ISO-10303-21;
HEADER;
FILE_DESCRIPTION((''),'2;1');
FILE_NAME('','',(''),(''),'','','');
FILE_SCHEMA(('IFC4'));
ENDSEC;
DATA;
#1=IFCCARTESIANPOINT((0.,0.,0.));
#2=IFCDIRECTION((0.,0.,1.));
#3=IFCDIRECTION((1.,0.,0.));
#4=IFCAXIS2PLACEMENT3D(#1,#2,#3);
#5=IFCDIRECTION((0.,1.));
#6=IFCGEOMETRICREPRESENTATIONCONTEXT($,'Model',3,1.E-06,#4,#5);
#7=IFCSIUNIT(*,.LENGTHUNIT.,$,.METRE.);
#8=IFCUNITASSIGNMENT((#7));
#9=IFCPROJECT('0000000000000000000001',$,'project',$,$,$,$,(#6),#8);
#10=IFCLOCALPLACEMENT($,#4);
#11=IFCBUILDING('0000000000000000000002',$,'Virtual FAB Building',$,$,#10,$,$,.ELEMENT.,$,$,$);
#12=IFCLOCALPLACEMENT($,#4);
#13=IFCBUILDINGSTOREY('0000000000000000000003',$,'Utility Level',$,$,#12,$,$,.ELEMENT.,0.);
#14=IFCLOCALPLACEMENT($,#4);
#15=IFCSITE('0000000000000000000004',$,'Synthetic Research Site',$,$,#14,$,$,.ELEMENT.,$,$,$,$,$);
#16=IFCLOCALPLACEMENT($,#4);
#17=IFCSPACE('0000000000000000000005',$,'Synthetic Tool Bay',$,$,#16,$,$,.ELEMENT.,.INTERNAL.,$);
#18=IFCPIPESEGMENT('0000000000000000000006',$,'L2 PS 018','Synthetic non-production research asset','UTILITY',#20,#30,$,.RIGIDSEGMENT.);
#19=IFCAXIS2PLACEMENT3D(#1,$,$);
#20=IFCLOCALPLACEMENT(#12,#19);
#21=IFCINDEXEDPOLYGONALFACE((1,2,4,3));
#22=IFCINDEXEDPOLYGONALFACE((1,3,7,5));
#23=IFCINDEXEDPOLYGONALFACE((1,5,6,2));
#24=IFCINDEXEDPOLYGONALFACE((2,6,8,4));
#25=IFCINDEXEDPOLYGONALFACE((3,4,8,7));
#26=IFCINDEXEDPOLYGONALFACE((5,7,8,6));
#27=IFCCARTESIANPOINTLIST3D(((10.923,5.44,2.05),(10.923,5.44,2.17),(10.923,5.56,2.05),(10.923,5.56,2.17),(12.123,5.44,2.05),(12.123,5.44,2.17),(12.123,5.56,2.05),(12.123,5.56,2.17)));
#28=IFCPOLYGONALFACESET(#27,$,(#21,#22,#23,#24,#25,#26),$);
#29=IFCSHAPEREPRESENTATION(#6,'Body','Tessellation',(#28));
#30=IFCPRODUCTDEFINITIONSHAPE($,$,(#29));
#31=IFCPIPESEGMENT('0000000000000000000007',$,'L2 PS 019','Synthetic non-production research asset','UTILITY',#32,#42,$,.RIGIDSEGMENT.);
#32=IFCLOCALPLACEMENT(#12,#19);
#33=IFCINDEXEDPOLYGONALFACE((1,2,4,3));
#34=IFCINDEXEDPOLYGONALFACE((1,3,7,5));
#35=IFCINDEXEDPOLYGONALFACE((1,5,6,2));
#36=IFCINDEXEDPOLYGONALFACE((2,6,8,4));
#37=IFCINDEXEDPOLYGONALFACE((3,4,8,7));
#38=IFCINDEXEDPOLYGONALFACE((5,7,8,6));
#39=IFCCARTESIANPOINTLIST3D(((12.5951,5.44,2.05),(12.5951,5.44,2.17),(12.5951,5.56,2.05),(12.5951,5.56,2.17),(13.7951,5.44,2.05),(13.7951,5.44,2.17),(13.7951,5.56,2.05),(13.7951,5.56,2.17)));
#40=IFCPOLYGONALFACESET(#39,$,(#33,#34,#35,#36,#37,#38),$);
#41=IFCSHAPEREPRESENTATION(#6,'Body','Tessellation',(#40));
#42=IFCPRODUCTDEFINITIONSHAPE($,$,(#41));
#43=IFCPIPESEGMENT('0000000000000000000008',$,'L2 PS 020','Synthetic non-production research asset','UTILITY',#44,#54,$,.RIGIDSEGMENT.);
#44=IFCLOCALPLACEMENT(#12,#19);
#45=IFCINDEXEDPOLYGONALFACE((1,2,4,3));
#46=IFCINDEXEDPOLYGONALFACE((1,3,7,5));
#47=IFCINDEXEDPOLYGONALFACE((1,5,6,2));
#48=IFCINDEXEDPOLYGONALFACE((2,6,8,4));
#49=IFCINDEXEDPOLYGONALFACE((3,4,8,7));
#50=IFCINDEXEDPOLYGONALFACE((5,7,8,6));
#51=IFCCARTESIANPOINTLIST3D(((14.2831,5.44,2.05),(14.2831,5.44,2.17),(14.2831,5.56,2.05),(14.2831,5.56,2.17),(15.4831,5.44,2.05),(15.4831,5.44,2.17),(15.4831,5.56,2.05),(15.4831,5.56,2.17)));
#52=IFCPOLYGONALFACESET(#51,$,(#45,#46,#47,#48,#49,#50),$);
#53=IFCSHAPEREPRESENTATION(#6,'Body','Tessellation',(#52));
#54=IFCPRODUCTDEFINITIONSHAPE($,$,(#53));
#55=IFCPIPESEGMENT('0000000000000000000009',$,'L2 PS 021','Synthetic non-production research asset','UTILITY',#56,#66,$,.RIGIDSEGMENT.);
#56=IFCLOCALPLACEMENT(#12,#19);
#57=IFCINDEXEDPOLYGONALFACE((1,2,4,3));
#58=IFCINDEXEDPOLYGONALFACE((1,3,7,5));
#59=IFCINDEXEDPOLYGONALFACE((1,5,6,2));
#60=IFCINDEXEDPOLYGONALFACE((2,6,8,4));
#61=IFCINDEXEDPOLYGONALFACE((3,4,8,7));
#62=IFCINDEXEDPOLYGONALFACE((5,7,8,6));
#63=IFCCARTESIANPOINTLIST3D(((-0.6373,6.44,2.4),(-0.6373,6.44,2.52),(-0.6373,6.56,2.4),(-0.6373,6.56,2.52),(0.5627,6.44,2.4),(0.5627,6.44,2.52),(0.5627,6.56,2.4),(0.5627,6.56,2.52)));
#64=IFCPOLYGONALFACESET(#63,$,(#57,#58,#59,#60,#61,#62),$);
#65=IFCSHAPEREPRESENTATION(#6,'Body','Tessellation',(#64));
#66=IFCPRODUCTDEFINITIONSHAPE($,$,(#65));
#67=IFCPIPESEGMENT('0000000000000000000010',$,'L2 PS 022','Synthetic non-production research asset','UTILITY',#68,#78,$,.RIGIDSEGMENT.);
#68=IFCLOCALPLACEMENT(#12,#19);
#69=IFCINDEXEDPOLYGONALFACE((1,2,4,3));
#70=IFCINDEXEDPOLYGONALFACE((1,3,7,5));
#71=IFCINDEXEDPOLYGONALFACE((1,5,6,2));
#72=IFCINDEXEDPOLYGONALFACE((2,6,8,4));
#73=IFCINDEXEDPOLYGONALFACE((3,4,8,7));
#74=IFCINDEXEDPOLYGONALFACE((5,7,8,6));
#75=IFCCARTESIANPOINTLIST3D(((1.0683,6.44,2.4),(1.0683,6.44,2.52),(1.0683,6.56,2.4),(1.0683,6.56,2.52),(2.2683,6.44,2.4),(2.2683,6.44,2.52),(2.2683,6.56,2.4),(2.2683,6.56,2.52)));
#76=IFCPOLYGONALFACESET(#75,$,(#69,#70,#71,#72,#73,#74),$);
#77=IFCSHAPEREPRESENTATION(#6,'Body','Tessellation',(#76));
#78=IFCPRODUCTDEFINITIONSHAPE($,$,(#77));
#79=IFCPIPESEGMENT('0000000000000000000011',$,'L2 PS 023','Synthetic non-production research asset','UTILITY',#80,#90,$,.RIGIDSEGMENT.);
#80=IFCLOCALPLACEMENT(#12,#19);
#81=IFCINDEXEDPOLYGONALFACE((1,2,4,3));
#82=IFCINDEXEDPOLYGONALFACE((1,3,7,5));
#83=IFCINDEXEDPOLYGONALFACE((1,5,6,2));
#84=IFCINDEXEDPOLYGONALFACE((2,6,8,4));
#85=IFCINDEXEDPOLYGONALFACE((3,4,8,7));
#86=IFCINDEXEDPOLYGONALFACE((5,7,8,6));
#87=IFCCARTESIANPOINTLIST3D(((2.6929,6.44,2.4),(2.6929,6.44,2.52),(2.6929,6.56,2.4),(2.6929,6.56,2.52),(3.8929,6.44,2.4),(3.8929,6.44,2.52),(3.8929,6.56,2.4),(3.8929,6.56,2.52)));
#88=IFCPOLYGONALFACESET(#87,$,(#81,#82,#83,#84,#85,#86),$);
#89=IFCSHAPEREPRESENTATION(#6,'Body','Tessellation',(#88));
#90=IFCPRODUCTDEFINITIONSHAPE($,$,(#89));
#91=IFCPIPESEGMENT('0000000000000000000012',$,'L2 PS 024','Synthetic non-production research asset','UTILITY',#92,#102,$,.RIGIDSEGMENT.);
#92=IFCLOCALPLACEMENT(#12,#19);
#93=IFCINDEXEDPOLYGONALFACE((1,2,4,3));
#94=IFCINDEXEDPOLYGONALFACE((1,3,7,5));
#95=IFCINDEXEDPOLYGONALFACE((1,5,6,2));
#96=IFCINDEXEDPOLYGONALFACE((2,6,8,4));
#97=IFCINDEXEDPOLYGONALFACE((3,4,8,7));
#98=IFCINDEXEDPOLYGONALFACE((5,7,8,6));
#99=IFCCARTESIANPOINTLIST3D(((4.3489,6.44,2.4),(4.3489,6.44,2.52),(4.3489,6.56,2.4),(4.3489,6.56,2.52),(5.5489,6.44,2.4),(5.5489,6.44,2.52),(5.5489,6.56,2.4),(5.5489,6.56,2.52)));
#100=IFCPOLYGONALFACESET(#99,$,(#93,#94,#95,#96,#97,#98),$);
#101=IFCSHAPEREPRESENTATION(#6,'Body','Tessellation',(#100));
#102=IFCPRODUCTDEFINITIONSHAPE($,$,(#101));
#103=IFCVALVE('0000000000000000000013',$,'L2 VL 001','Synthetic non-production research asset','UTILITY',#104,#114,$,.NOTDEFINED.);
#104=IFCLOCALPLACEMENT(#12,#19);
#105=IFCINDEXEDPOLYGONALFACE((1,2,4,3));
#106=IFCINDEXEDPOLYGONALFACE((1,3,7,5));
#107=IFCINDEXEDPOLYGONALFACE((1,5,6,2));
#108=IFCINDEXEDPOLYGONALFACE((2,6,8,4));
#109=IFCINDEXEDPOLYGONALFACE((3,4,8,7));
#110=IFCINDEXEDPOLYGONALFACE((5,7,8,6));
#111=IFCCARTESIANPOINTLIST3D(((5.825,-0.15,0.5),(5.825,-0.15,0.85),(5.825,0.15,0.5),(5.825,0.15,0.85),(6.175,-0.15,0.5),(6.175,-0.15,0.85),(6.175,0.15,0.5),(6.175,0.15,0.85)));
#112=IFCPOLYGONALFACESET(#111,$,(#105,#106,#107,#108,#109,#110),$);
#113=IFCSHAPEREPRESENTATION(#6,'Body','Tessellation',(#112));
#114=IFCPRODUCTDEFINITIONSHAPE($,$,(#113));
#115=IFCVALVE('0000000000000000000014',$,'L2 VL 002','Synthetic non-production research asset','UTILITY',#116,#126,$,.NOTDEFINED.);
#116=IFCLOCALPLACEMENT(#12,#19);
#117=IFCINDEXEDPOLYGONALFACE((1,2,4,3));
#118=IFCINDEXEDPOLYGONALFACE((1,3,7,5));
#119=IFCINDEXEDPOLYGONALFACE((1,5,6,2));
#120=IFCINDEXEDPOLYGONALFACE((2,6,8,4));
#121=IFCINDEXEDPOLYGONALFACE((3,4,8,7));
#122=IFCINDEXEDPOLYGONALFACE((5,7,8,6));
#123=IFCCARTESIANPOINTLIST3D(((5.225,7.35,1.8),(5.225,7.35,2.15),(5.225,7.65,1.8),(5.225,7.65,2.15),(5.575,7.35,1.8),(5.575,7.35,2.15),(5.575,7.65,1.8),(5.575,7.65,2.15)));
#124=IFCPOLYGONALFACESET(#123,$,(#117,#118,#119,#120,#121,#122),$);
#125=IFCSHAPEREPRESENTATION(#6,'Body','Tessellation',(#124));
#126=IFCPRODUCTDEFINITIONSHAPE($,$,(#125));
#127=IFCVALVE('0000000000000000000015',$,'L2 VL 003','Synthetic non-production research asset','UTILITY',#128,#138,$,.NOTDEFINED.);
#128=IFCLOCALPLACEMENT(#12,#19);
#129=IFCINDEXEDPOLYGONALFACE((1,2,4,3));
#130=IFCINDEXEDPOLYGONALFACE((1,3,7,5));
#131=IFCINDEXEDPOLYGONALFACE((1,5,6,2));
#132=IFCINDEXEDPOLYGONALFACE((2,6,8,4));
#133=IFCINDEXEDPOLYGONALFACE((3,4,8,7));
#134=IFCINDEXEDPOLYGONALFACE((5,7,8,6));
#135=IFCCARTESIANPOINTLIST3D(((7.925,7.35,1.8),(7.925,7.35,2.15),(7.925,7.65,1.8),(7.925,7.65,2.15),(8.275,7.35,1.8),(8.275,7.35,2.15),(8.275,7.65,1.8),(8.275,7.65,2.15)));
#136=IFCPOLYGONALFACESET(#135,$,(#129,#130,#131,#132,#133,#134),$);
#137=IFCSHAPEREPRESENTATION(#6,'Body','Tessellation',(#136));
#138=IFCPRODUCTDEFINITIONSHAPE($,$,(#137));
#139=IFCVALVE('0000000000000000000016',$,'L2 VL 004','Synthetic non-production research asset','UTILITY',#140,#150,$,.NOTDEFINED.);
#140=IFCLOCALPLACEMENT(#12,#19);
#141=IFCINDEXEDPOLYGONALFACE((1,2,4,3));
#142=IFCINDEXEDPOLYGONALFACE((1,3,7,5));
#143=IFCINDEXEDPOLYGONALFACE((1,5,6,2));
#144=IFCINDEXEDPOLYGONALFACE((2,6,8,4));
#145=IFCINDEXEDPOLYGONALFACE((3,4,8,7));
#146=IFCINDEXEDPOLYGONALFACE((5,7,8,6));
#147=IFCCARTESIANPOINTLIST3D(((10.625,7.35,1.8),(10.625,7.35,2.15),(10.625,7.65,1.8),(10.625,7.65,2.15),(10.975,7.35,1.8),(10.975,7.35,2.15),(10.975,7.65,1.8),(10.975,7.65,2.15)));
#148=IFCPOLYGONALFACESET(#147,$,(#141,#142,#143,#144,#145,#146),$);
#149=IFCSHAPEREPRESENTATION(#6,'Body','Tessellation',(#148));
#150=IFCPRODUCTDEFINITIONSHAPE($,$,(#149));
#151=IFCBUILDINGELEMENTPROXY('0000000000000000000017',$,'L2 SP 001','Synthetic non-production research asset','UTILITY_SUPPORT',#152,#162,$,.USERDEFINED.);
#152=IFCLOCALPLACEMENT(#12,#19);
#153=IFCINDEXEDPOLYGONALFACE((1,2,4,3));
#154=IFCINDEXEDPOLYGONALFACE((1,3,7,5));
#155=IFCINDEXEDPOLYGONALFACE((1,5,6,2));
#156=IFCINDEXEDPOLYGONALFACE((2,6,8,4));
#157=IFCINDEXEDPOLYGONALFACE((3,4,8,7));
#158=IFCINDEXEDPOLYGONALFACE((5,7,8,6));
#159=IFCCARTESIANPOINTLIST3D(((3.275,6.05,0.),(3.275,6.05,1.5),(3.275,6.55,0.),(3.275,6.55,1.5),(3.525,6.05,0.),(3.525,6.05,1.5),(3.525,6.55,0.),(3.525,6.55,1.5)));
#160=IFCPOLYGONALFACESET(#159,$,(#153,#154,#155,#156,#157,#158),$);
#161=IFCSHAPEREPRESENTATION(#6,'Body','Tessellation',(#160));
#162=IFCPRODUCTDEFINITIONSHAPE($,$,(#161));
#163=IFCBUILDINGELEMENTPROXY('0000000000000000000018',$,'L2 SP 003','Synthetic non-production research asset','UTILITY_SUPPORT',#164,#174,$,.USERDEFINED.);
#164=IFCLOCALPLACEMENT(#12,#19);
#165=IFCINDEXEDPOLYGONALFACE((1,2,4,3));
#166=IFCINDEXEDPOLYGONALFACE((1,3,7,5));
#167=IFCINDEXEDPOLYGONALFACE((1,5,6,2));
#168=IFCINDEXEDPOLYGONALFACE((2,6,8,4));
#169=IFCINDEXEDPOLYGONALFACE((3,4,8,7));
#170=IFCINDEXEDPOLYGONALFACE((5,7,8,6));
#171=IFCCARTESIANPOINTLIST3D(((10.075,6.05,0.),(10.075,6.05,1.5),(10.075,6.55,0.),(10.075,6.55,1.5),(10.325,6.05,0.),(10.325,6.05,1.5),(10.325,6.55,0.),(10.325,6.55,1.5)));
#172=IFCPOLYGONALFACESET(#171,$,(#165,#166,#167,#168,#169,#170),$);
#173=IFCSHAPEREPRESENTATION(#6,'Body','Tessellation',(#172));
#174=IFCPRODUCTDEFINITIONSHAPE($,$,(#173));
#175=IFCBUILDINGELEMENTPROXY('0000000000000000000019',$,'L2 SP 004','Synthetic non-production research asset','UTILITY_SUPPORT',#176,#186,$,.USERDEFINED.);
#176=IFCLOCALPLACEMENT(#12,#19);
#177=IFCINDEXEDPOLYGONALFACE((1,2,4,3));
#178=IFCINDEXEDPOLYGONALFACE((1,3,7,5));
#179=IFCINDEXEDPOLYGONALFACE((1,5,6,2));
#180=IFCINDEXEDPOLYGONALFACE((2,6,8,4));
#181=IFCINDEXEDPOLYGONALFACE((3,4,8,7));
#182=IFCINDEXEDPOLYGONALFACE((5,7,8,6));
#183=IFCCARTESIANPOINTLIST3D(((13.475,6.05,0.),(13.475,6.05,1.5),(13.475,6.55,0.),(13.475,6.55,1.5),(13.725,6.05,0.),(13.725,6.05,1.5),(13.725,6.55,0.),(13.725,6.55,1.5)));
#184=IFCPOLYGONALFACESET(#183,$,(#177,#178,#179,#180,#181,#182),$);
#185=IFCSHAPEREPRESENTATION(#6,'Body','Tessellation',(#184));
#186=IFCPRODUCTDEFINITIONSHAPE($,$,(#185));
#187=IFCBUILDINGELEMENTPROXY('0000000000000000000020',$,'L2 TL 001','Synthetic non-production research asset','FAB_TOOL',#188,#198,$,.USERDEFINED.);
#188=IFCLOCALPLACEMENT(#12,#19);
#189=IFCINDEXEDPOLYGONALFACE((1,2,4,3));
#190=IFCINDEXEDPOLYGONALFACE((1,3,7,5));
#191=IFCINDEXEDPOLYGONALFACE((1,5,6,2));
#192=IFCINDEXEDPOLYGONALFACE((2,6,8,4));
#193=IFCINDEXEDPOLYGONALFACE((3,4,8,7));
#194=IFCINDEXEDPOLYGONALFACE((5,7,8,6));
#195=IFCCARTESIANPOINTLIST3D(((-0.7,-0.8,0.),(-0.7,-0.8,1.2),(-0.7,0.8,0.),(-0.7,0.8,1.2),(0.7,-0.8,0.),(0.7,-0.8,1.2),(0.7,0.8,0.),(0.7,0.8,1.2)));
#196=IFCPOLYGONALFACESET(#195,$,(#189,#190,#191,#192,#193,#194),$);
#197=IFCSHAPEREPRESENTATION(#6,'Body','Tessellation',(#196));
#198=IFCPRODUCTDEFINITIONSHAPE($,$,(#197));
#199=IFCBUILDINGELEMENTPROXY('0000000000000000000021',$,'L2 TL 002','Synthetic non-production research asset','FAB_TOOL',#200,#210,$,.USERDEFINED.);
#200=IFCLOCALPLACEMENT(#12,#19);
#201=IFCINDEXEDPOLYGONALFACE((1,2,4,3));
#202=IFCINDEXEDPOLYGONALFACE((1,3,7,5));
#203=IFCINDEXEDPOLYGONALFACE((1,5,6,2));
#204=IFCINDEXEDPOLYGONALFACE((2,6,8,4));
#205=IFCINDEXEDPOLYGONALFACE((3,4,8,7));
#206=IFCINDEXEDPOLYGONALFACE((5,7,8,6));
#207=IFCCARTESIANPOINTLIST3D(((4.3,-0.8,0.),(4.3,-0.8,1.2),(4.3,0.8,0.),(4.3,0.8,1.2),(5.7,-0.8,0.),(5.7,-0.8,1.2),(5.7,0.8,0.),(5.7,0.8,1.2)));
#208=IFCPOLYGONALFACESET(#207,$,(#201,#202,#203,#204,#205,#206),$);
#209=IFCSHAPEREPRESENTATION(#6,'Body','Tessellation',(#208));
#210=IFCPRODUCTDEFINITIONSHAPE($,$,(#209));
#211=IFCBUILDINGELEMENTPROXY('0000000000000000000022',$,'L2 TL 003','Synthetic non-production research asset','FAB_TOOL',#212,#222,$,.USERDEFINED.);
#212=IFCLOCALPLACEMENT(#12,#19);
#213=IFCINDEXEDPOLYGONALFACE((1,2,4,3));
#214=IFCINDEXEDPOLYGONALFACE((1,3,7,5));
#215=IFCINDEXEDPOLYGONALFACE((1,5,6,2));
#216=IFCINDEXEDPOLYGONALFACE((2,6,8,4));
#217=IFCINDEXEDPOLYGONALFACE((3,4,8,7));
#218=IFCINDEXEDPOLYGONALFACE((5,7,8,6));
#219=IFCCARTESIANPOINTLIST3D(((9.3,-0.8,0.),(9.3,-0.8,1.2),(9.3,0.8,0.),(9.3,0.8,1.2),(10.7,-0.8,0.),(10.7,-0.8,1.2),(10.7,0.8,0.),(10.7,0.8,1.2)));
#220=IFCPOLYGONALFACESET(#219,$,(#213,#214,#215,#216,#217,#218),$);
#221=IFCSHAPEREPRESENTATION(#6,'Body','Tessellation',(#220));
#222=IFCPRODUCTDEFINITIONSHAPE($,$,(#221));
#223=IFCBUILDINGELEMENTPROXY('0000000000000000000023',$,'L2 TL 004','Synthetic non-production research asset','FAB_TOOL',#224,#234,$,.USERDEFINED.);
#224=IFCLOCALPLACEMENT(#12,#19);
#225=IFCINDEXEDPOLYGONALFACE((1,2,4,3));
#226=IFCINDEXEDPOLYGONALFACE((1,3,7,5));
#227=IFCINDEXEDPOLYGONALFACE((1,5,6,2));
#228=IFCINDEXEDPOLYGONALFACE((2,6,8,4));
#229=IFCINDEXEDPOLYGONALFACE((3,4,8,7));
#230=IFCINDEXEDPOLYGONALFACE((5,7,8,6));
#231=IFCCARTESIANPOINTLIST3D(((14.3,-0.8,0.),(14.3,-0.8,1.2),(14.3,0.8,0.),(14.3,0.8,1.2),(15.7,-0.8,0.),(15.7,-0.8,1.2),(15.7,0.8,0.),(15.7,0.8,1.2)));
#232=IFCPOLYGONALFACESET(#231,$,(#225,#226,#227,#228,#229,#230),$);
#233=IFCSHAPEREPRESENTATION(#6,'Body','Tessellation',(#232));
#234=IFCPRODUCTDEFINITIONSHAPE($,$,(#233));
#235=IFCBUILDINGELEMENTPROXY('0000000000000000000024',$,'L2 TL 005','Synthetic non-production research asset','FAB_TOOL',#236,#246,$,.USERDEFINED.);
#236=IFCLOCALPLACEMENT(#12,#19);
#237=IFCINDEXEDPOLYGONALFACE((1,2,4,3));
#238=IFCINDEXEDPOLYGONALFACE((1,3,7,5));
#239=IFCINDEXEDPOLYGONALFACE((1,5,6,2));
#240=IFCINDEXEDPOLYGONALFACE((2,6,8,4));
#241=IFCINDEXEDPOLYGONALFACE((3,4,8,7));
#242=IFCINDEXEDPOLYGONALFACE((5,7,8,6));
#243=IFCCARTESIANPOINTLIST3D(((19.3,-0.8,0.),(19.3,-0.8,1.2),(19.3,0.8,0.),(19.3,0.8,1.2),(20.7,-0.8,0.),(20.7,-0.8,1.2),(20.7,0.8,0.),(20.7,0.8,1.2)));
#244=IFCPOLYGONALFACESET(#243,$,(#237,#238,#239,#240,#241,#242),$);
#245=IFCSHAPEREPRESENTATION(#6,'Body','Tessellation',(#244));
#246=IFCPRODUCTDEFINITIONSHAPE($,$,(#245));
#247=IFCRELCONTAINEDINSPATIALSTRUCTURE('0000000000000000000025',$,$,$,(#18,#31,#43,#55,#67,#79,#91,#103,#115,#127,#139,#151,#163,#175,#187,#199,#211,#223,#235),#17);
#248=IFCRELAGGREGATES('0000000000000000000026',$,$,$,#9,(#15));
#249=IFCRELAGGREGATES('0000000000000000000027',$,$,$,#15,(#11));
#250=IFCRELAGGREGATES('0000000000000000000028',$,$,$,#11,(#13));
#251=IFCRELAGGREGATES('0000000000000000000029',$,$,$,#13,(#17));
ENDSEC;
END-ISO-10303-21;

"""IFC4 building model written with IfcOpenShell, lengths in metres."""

from ifc_helpers import new_model, si_unit, direction, frame, origin_with_axes, origin_2d_with_axis, place, context, project, spatial, rectangle, extrude, element, save


model = new_model("IFC4")

# Units and contexts
model_context = context("Model", 3, precision=1e-06, world=origin_with_axes(), true_north=direction((0.0, 1.0)))
ifc_project = project(units=[si_unit("LENGTHUNIT", "METRE")], contexts=[model_context])

# Site, building, storey, space
site_placement = place(None, origin_with_axes())
site = spatial("IfcSite", under=ifc_project, at=site_placement, Name="Synthetic Research Site", CompositionType="ELEMENT")
building_placement = place(None, origin_with_axes())
building = spatial("IfcBuilding", under=site, at=building_placement, Name="Virtual FAB Building", CompositionType="ELEMENT")
storey_placement = place(None, origin_with_axes())
storey = spatial("IfcBuildingStorey", under=building, at=storey_placement, Name="Utility Level", CompositionType="ELEMENT", Elevation=0.0)
space_placement = place(None, origin_with_axes())
space = spatial("IfcSpace", under=storey, at=space_placement, Name="Synthetic Tool Bay", CompositionType="ELEMENT", PredefinedType="INTERNAL")

# Pipe segments
for number, where, z_axis, x_axis, name in (
    (1, (11.523, 5.5, 2.05), (0.0, 0.0, 1.0), (1.0, 0.0, 0.0), "L2 PS 018"),
    (2, (13.1951, 5.5, 2.05), (0.0, 0.0, 1.0), (1.0, 0.0, 0.0), "L2 PS 019"),
    (3, (14.8831, 5.5, 2.05), (0.0, 0.0, 1.0), (1.0, 0.0, 0.0), "L2 PS 020"),
    (4, (-0.0373, 6.5, 2.4), (0.0, 0.0, 1.0), (1.0, 0.0, 0.0), "L2 PS 021"),
    (5, (1.6683, 6.5, 2.4), (0.0, 0.0, 1.0), (1.0, 0.0, 0.0), "L2 PS 022"),
    (6, (3.2929, 6.5, 2.4), (0.0, 0.0, 1.0), (1.0, 0.0, 0.0), "L2 PS 023"),
    (7, (4.9489, 6.5, 2.4), (0.0, 0.0, 1.0), (1.0, 0.0, 0.0), "L2 PS 024"),
):
    element("IfcPipeSegment", number, at=place(None, frame(where, z_axis=z_axis, x_axis=x_axis)), inside=space, Name=name, Description="Synthetic non-production research asset", ObjectType="UTILITY", PredefinedType="RIGIDSEGMENT", context=model_context, shape_type="SweptSolid", body=[
        extrude(rectangle(XDim=1.2, YDim=0.12, at=origin_2d_with_axis()), origin_with_axes(), (0.0, 0.0, 1.0), 0.12),
    ])

# Valves
for number, where, z_axis, x_axis, name in (
    (8, (6.0, 0.0, 0.5), (0.0, 0.0, 1.0), (1.0, 0.0, 0.0), "L2 VL 001"),
    (9, (5.4, 7.5, 1.8), (0.0, 0.0, 1.0), (1.0, 0.0, 0.0), "L2 VL 002"),
    (10, (8.1, 7.5, 1.8), (0.0, 0.0, 1.0), (1.0, 0.0, 0.0), "L2 VL 003"),
    (11, (10.8, 7.5, 1.8), (0.0, 0.0, 1.0), (1.0, 0.0, 0.0), "L2 VL 004"),
):
    element("IfcValve", number, at=place(None, frame(where, z_axis=z_axis, x_axis=x_axis)), inside=space, Name=name, Description="Synthetic non-production research asset", ObjectType="UTILITY", PredefinedType="NOTDEFINED", context=model_context, shape_type="SweptSolid", body=[
        extrude(rectangle(XDim=0.35, YDim=0.3, at=origin_2d_with_axis()), origin_with_axes(), (0.0, 0.0, 1.0), 0.35),
    ])

# Building element proxies
for number, where, z_axis, x_axis, name in (
    (12, (3.4, 6.3, 0.0), (0.0, 0.0, 1.0), (1.0, 0.0, 0.0), "L2 SP 001"),
    (13, (10.2, 6.3, 0.0), (0.0, 0.0, 1.0), (1.0, 0.0, 0.0), "L2 SP 003"),
    (14, (13.6, 6.3, 0.0), (0.0, 0.0, 1.0), (1.0, 0.0, 0.0), "L2 SP 004"),
):
    element("IfcBuildingElementProxy", number, at=place(None, frame(where, z_axis=z_axis, x_axis=x_axis)), inside=space, Name=name, Description="Synthetic non-production research asset", ObjectType="UTILITY_SUPPORT", PredefinedType="USERDEFINED", context=model_context, shape_type="SweptSolid", body=[
        extrude(rectangle(XDim=0.25, YDim=0.5, at=origin_2d_with_axis()), origin_with_axes(), (0.0, 0.0, 1.0), 1.5),
    ])
for number, where, z_axis, x_axis, name in (
    (15, (0.0, 0.0, 0.0), (0.0, 0.0, 1.0), (1.0, 0.0, 0.0), "L2 TL 001"),
    (16, (5.0, 0.0, 0.0), (0.0, 0.0, 1.0), (1.0, 0.0, 0.0), "L2 TL 002"),
    (17, (10.0, 0.0, 0.0), (0.0, 0.0, 1.0), (1.0, 0.0, 0.0), "L2 TL 003"),
    (18, (15.0, 0.0, 0.0), (0.0, 0.0, 1.0), (1.0, 0.0, 0.0), "L2 TL 004"),
    (19, (20.0, 0.0, 0.0), (0.0, 0.0, 1.0), (1.0, 0.0, 0.0), "L2 TL 005"),
):
    element("IfcBuildingElementProxy", number, at=place(None, frame(where, z_axis=z_axis, x_axis=x_axis)), inside=space, Name=name, Description="Synthetic non-production research asset", ObjectType="FAB_TOOL", PredefinedType="USERDEFINED", context=model_context, shape_type="SweptSolid", body=[
        extrude(rectangle(XDim=1.4, YDim=1.6, at=origin_2d_with_axis()), origin_with_axes(), (0.0, 0.0, 1.0), 1.2),
    ])

save(model, "model.ifc")
